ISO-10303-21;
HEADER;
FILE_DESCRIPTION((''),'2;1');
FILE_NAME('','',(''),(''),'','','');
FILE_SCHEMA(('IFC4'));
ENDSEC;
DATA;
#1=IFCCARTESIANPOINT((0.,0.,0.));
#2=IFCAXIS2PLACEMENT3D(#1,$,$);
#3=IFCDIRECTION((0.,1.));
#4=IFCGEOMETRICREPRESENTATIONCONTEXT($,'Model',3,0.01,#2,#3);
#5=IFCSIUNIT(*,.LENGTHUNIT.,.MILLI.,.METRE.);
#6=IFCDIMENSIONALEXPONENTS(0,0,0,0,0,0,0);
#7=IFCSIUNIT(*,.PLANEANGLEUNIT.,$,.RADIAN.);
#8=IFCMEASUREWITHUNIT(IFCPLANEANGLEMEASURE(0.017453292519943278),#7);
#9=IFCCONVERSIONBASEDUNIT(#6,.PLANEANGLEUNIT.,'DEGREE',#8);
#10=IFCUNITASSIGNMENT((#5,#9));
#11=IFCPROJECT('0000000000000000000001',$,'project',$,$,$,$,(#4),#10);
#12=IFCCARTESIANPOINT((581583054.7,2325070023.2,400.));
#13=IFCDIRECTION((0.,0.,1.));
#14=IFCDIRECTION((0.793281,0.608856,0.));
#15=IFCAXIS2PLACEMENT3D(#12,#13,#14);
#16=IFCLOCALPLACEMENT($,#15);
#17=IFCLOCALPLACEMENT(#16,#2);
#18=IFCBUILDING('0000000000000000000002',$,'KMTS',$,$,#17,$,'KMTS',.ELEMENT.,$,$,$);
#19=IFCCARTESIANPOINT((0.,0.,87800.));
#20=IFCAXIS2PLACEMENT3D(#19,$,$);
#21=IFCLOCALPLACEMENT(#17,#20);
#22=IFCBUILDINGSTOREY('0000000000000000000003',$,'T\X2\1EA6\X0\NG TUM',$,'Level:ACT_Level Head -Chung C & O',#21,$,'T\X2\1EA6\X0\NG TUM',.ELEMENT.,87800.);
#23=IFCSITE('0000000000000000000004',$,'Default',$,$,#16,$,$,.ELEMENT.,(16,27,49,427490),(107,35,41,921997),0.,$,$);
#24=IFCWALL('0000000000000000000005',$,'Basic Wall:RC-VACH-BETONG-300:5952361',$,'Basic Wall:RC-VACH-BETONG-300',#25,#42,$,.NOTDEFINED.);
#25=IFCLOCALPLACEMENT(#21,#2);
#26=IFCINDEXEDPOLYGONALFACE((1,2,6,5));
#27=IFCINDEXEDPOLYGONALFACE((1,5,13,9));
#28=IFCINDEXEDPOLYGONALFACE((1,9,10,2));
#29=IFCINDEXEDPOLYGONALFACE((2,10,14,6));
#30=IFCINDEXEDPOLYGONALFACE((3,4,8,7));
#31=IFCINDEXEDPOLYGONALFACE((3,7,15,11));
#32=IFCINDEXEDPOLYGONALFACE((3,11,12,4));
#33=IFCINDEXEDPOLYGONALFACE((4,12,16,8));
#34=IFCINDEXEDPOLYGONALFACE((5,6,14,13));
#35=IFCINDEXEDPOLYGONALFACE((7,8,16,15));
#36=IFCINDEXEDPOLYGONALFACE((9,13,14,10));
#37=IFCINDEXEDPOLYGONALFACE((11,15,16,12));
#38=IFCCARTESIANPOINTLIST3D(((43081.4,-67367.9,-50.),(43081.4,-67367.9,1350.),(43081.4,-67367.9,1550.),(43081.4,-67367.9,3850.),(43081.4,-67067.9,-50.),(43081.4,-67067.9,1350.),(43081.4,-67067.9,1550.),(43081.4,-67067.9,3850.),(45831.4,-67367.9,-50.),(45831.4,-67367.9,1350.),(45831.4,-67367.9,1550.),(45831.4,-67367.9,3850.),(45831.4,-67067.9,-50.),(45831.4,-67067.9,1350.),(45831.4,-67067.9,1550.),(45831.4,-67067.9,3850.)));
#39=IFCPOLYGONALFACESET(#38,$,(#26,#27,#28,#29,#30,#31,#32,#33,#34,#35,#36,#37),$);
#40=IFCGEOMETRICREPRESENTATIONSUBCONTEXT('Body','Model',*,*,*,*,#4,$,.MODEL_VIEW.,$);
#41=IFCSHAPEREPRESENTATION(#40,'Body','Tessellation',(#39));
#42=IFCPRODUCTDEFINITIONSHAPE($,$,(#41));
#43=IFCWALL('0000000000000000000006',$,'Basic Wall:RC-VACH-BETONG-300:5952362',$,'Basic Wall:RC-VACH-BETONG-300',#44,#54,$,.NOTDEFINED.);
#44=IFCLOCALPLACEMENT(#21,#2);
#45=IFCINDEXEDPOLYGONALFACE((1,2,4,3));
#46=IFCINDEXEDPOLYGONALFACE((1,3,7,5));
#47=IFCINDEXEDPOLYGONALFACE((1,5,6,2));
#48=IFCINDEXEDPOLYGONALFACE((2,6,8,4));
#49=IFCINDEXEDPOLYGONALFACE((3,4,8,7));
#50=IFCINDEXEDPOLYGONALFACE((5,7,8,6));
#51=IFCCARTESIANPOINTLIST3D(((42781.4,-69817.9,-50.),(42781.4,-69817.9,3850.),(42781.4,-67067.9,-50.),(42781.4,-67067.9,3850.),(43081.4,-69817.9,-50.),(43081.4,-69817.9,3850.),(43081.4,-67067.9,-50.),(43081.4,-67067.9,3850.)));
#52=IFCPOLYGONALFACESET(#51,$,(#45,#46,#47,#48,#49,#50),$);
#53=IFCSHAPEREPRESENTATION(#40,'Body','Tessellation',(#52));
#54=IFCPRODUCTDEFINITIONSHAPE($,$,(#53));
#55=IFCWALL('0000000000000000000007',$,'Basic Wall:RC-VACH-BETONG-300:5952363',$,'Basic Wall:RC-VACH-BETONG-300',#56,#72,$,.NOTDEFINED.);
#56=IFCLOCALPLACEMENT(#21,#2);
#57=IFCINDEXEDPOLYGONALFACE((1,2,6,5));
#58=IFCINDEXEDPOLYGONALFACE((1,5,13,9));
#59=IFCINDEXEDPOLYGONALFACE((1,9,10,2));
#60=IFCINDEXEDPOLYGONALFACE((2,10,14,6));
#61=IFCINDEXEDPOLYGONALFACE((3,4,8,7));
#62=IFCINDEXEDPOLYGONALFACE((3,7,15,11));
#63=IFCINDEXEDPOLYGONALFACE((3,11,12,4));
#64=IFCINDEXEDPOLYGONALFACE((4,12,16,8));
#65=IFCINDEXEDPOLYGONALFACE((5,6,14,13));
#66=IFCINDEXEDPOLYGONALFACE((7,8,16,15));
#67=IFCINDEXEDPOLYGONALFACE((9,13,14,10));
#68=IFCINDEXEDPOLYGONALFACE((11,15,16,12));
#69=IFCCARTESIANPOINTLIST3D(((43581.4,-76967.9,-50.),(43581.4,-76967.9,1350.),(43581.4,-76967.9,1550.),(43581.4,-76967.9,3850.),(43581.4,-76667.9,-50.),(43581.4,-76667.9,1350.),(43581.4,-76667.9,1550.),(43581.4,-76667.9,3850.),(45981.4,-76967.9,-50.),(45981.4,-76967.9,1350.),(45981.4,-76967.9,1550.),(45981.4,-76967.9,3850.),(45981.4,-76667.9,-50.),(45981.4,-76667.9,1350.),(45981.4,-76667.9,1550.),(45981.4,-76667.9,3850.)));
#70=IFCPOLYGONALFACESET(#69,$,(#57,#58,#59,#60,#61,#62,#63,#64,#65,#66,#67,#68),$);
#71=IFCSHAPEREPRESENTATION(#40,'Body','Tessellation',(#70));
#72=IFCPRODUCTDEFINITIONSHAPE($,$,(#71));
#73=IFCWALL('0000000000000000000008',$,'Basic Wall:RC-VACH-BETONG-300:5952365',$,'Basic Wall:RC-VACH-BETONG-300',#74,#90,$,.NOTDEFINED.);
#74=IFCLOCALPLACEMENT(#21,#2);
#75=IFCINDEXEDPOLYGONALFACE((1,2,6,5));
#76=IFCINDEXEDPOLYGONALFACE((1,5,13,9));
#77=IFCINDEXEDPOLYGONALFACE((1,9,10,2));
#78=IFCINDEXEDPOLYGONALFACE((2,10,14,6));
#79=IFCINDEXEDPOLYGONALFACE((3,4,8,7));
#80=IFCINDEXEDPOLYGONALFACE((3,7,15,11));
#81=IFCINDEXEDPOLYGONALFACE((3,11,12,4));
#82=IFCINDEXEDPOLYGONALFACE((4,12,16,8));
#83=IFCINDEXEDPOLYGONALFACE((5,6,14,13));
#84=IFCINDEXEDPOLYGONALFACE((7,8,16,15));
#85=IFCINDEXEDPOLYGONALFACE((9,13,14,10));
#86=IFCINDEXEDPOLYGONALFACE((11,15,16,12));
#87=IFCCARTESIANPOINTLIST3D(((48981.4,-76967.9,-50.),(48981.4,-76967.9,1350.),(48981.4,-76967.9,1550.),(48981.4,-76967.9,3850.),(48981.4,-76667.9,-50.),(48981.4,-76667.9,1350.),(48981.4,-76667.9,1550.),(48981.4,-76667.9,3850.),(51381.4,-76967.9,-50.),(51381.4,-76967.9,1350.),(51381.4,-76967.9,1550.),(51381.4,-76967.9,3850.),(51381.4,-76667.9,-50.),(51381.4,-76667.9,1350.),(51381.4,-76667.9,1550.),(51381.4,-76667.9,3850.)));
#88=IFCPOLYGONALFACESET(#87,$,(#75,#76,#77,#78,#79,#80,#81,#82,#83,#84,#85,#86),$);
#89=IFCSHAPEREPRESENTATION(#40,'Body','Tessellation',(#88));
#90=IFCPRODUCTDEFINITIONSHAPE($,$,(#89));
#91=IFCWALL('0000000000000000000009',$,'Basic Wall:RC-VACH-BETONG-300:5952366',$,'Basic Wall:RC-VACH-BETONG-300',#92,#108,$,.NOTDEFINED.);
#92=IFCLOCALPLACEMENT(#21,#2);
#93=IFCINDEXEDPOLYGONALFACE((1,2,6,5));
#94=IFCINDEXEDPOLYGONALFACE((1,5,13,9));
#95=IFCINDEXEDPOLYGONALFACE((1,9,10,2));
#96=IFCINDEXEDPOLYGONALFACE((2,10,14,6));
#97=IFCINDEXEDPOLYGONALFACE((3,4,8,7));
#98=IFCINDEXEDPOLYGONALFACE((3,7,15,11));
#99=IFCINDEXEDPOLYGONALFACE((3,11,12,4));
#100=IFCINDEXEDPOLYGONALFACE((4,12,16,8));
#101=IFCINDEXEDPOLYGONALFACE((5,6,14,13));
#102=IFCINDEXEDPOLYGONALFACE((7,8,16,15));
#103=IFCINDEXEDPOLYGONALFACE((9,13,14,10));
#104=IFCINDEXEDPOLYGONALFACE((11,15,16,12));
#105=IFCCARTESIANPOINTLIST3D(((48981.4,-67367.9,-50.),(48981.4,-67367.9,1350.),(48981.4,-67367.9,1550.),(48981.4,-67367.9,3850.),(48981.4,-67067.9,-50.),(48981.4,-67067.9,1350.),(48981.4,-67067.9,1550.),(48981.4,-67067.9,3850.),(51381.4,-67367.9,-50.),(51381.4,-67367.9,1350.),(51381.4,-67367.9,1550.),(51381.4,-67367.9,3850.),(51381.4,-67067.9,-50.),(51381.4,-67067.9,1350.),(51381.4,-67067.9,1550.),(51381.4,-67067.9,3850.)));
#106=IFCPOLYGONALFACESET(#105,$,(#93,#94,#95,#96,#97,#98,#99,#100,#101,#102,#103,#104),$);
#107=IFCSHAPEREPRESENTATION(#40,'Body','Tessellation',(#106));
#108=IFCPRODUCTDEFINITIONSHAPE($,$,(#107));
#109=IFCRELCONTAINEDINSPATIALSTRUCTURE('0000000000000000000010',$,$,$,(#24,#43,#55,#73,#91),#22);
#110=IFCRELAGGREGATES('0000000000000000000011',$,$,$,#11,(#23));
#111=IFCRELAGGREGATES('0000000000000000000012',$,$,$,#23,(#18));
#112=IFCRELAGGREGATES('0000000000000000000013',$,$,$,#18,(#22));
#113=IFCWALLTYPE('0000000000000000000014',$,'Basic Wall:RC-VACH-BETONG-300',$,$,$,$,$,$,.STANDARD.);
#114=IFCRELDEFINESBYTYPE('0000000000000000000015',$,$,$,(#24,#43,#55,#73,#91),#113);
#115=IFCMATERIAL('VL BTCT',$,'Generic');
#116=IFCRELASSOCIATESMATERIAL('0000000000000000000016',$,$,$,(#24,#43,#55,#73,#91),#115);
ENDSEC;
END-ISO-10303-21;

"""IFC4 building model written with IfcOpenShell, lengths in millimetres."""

from ifc_helpers import new_model, entity, si_unit, converted_unit, direction, frame, origin, place, context, subcontext, project, spatial, indexed_curve, outline, extrude, material, type_object, element, save


model = new_model("IFC4")

# Units and contexts
model_context = context("Model", 3, precision=0.01, world=origin(), true_north=direction((0.0, 1.0)))
body_context = subcontext(model_context, "Body", "Model", "MODEL_VIEW")
ifc_project = project(units=[si_unit("LENGTHUNIT", "METRE", prefix="MILLI"), converted_unit("PLANEANGLEUNIT", "DEGREE", entity("IfcPlaneAngleMeasure", 0.017453292519943278), si_unit("PLANEANGLEUNIT", "RADIAN"), dimensions=[0, 0, 0, 0, 0, 0, 0])], contexts=[model_context])

# Site, building, storey
site_placement = place(None, frame((581583054.7, 2325070023.2, 400.0), z_axis=(0.0, 0.0, 1.0), x_axis=(0.793281, 0.608856, 0.0)))
site = spatial("IfcSite", under=ifc_project, at=site_placement, Name="Default", CompositionType="ELEMENT", RefLatitude=(16, 27, 49, 427490), RefLongitude=(107, 35, 41, 921997), RefElevation=0.0)
building_placement = place(site_placement, origin())
building = spatial("IfcBuilding", under=site, at=building_placement, Name="KMTS", LongName="KMTS", CompositionType="ELEMENT")
storey_placement = place(building_placement, frame((0.0, 0.0, 87800.0)))
storey = spatial("IfcBuildingStorey", under=building, at=storey_placement, Name="TẦNG TUM", ObjectType="Level:ACT_Level Head -Chung C & O", LongName="TẦNG TUM", CompositionType="ELEMENT", Elevation=87800.0)

# Shared definitions
ifc_material = material(Name="VL BTCT", Category="Generic")

# Wall, opening
wall_type = type_object("IfcWallType", Name="Basic Wall:RC-VACH-BETONG-300", PredefinedType="STANDARD")
wall_1_placement = place(storey_placement, frame((45831.4, -67217.9, -50.0), z_axis=(0.0, 0.0, 1.0), x_axis=(-1.0, 0.0, 0.0)))
wall_1 = element("IfcWall", 1, at=wall_1_placement, inside=storey, type_object=wall_type, material=ifc_material, Name="Basic Wall:RC-VACH-BETONG-300:5952361", ObjectType="Basic Wall:RC-VACH-BETONG-300", PredefinedType="NOTDEFINED", context=body_context, shape_type="SweptSolid", body=[
    extrude(outline(indexed_curve([(2750.0, 150.0), (0.0, 150.0), (0.0, -150.0), (2750.0, -150.0), (2750.0, 150.0)], self_intersect=False)), origin(), (0.0, 0.0, 1.0), 3900.0),
])
opening_1_placement = place(storey_placement, frame((45831.4, -67217.9, -50.0), z_axis=(0.0, 0.0, 1.0), x_axis=(-1.0, 0.0, 0.0)))
element("IfcOpeningElement", 2, at=opening_1_placement, cuts=wall_1, PredefinedType="OPENING", context=body_context, shape_type="SweptSolid", body=[
    extrude(outline(indexed_curve([(-1375.0, -150.0), (1375.0, -150.0), (1375.0, 150.0), (-1375.0, 150.0), (-1375.0, -150.0)], self_intersect=False)), frame((1375.0, 0.0, 1400.0)), (0.0, 0.0, 1.0), 200.0),
])

# Wall
wall_2_placement = place(storey_placement, frame((42931.4, -67067.9, -50.0), z_axis=(0.0, 0.0, 1.0), x_axis=(0.0, -1.0, 0.0)))
element("IfcWall", 3, at=wall_2_placement, inside=storey, type_object=wall_type, material=ifc_material, Name="Basic Wall:RC-VACH-BETONG-300:5952362", ObjectType="Basic Wall:RC-VACH-BETONG-300", PredefinedType="NOTDEFINED", context=body_context, shape_type="SweptSolid", body=[
    extrude(outline(indexed_curve([(2750.0, 150.0), (0.0, 150.0), (0.0, -150.0), (2750.0, -150.0), (2750.0, 150.0)], self_intersect=False)), origin(), (0.0, 0.0, 1.0), 3900.0),
])

# Walls, openings
wall_3_placement = place(storey_placement, frame((45981.4, -76817.9, -50.0), z_axis=(0.0, 0.0, 1.0), x_axis=(-1.0, 0.0, 0.0)))
wall_3 = element("IfcWall", 4, at=wall_3_placement, inside=storey, type_object=wall_type, material=ifc_material, Name="Basic Wall:RC-VACH-BETONG-300:5952363", ObjectType="Basic Wall:RC-VACH-BETONG-300", PredefinedType="NOTDEFINED", context=body_context, shape_type="SweptSolid", body=[
    extrude(outline(indexed_curve([(2400.0, 150.0), (0.0, 150.0), (0.0, -150.0), (2400.0, -150.0), (2400.0, 150.0)], self_intersect=False)), origin(), (0.0, 0.0, 1.0), 3900.0),
])
opening_2_placement = place(storey_placement, frame((45981.4, -76817.9, -50.0), z_axis=(0.0, 0.0, 1.0), x_axis=(-1.0, 0.0, 0.0)))
element("IfcOpeningElement", 5, at=opening_2_placement, cuts=wall_3, PredefinedType="OPENING", context=body_context, shape_type="SweptSolid", body=[
    extrude(outline(indexed_curve([(-1200.0, -150.0), (1200.0, -150.0), (1200.0, 150.0), (-1200.0, 150.0), (-1200.0, -150.0)], self_intersect=False)), frame((1200.0, 0.0, 1400.0)), (0.0, 0.0, 1.0), 200.0),
])
wall_4_placement = place(storey_placement, frame((51381.4, -76817.9, -50.0), z_axis=(0.0, 0.0, 1.0), x_axis=(-1.0, 0.0, 0.0)))
wall_4 = element("IfcWall", 6, at=wall_4_placement, inside=storey, type_object=wall_type, material=ifc_material, Name="Basic Wall:RC-VACH-BETONG-300:5952365", ObjectType="Basic Wall:RC-VACH-BETONG-300", PredefinedType="NOTDEFINED", context=body_context, shape_type="SweptSolid", body=[
    extrude(outline(indexed_curve([(2400.0, 150.0), (0.0, 150.0), (0.0, -150.0), (2400.0, -150.0), (2400.0, 150.0)], self_intersect=False)), origin(), (0.0, 0.0, 1.0), 3900.0),
])
opening_3_placement = place(storey_placement, frame((51381.4, -76817.9, -50.0), z_axis=(0.0, 0.0, 1.0), x_axis=(-1.0, 0.0, 0.0)))
element("IfcOpeningElement", 7, at=opening_3_placement, cuts=wall_4, PredefinedType="OPENING", context=body_context, shape_type="SweptSolid", body=[
    extrude(outline(indexed_curve([(-1200.0, -150.0), (1200.0, -150.0), (1200.0, 150.0), (-1200.0, 150.0), (-1200.0, -150.0)], self_intersect=False)), frame((1200.0, 0.0, 1400.0)), (0.0, 0.0, 1.0), 200.0),
])
wall_5_placement = place(storey_placement, frame((51381.4, -67217.9, -50.0), z_axis=(0.0, 0.0, 1.0), x_axis=(-1.0, 0.0, 0.0)))
wall_5 = element("IfcWall", 8, at=wall_5_placement, inside=storey, type_object=wall_type, material=ifc_material, Name="Basic Wall:RC-VACH-BETONG-300:5952366", ObjectType="Basic Wall:RC-VACH-BETONG-300", PredefinedType="NOTDEFINED", context=body_context, shape_type="SweptSolid", body=[
    extrude(outline(indexed_curve([(2400.0, 150.0), (0.0, 150.0), (0.0, -150.0), (2400.0, -150.0), (2400.0, 150.0)], self_intersect=False)), origin(), (0.0, 0.0, 1.0), 3900.0),
])
opening_4_placement = place(storey_placement, frame((51381.4, -67217.9, -50.0), z_axis=(0.0, 0.0, 1.0), x_axis=(-1.0, 0.0, 0.0)))
element("IfcOpeningElement", 9, at=opening_4_placement, cuts=wall_5, PredefinedType="OPENING", context=body_context, shape_type="SweptSolid", body=[
    extrude(outline(indexed_curve([(-1200.0, -150.0), (1200.0, -150.0), (1200.0, 150.0), (-1200.0, 150.0), (-1200.0, -150.0)], self_intersect=False)), frame((1200.0, 0.0, 1400.0)), (0.0, 0.0, 1.0), 200.0),
])

save(model, "model.ifc")
